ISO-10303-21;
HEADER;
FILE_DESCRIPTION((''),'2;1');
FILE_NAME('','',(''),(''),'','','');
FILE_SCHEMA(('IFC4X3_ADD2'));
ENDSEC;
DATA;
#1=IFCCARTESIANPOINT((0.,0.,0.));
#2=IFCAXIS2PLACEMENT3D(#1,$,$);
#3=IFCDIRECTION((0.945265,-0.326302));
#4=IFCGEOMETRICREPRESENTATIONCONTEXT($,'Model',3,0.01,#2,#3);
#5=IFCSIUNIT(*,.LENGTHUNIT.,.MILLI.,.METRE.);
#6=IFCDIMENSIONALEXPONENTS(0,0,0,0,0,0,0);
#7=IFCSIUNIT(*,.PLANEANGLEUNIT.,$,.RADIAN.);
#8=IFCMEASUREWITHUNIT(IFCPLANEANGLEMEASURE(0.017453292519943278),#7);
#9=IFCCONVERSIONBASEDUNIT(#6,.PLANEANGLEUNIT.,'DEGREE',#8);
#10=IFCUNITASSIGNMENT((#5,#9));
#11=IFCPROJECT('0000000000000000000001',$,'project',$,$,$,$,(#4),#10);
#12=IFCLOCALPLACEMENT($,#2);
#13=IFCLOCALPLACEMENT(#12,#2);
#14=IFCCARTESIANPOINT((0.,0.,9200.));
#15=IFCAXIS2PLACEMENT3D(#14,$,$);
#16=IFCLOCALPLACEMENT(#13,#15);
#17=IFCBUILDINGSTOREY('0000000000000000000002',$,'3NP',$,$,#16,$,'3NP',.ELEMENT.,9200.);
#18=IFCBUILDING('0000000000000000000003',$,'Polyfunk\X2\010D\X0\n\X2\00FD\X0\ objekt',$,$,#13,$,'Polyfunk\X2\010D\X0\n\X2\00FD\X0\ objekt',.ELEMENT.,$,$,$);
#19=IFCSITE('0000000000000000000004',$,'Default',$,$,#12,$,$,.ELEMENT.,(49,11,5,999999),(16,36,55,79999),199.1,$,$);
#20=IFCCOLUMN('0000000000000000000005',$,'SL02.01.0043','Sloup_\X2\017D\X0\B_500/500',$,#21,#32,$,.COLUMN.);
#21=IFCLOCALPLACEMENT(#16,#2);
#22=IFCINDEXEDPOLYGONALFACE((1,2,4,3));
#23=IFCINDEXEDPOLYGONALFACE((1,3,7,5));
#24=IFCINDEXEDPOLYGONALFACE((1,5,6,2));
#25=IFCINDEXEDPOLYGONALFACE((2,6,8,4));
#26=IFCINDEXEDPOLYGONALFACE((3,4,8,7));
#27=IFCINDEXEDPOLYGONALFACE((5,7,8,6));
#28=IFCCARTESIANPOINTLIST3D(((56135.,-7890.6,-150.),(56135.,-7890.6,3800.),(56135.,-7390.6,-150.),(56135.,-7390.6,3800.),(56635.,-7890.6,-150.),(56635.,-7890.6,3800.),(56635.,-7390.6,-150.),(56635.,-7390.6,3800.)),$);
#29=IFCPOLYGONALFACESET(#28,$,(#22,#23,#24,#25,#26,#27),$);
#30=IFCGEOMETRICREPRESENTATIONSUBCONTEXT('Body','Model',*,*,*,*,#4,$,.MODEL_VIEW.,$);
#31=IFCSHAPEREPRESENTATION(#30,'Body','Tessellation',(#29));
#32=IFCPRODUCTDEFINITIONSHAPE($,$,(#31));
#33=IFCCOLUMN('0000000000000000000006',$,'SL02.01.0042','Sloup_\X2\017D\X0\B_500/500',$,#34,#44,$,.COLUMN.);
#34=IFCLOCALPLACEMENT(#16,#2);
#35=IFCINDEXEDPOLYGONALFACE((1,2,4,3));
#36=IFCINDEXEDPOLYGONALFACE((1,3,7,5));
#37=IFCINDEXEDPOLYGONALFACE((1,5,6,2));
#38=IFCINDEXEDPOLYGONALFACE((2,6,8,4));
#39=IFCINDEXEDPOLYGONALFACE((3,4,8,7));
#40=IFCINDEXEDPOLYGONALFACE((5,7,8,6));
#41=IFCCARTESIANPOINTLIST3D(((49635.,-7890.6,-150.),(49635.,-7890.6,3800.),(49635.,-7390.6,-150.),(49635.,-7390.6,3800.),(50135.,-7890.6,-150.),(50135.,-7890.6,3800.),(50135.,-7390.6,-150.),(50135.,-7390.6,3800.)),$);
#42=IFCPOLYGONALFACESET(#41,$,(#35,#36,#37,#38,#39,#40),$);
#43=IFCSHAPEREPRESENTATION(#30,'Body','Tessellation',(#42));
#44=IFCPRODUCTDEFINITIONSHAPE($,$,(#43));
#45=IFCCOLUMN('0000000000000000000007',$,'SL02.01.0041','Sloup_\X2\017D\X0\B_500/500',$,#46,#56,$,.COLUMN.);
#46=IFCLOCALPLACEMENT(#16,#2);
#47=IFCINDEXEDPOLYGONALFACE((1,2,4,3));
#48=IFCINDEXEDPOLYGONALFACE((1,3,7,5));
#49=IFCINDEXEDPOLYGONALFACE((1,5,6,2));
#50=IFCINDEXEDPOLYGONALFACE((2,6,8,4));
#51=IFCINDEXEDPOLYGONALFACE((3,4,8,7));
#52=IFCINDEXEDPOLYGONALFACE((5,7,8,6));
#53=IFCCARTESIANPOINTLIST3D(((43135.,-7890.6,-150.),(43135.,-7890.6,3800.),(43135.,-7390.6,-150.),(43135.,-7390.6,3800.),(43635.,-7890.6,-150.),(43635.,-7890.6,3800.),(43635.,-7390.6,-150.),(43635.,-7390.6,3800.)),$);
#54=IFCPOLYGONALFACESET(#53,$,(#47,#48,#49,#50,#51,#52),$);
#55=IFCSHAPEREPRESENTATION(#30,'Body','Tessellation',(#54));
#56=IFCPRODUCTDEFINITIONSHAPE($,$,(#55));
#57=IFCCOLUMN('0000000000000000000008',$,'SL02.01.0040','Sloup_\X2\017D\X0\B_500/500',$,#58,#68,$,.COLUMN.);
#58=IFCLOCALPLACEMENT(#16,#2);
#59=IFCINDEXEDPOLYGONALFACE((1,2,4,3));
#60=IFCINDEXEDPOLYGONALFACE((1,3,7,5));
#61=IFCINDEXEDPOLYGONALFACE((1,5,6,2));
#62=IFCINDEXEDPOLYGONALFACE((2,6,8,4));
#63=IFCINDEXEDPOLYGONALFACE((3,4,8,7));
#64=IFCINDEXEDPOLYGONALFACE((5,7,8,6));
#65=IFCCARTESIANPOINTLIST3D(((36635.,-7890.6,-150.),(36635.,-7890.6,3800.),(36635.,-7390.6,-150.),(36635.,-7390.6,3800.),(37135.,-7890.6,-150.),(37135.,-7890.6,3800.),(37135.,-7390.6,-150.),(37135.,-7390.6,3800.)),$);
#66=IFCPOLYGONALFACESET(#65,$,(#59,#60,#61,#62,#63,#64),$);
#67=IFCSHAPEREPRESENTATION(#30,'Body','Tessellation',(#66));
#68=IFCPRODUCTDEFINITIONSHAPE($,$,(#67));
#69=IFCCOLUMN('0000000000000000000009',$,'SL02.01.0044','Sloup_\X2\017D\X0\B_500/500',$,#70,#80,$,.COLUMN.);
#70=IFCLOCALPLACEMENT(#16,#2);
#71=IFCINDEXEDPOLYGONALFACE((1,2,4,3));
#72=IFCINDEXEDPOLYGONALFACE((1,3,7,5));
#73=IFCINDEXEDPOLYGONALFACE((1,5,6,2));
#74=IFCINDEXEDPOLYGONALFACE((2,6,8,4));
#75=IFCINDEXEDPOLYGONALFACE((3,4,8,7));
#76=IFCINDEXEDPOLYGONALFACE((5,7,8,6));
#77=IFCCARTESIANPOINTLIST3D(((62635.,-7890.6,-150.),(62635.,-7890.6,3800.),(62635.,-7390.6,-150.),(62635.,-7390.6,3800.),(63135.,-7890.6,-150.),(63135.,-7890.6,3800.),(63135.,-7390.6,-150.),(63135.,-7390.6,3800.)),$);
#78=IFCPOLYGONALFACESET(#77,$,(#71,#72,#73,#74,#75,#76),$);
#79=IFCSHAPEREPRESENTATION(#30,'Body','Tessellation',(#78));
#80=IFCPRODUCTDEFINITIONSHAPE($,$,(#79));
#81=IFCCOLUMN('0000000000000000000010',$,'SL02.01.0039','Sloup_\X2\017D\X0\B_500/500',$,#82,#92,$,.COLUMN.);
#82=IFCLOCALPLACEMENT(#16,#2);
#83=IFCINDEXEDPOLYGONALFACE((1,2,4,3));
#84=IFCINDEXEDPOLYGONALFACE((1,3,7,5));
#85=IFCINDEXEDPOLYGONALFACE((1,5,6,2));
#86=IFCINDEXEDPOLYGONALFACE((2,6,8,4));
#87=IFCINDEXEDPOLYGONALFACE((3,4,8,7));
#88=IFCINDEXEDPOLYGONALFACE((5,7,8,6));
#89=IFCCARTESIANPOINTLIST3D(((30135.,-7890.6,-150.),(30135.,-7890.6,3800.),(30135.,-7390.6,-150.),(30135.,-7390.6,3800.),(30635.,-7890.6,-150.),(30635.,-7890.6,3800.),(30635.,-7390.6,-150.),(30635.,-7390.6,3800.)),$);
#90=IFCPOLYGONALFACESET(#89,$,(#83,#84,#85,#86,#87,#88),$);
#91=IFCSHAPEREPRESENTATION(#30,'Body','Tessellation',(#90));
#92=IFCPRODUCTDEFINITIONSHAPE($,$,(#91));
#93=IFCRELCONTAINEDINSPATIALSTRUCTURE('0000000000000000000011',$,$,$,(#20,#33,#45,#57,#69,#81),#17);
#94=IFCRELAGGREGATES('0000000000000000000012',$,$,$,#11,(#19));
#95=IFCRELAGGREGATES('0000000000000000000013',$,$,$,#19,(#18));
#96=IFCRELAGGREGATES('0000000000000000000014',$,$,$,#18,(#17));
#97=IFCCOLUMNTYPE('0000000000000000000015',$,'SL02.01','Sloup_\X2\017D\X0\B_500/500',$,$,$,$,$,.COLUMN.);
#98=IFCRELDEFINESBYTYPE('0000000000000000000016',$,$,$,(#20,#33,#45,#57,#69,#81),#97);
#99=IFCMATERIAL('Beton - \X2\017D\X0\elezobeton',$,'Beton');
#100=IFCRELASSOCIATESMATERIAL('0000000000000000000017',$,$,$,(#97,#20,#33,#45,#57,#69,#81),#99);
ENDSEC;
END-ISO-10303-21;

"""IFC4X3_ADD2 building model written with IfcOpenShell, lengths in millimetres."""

from ifc_helpers import new_model, entity, si_unit, converted_unit, direction, frame, frame_2d, origin, origin_2d_with_axis, place, context, subcontext, project, spatial, rectangle, extrude, source, transform, mapped, material, material_profile, profile_set, profile_usage, type_object, element, save


model = new_model("IFC4X3_ADD2")

# Units and contexts
model_context = context("Model", 3, precision=0.01, world=origin(), true_north=direction((0.945265, -0.326302)))
body_context = subcontext(model_context, "Body", "Model", "MODEL_VIEW")
ifc_project = project(units=[si_unit("LENGTHUNIT", "METRE", prefix="MILLI"), converted_unit("PLANEANGLEUNIT", "DEGREE", entity("IfcPlaneAngleMeasure", 0.017453292519943278), si_unit("PLANEANGLEUNIT", "RADIAN"), dimensions=[0, 0, 0, 0, 0, 0, 0])], contexts=[model_context])

# Site, building, storey
site_placement = place(None, origin())
site = spatial("IfcSite", under=ifc_project, at=site_placement, Name="Default", CompositionType="ELEMENT", RefLatitude=(49, 11, 5, 999999), RefLongitude=(16, 36, 55, 79999), RefElevation=199.1)
building_placement = place(site_placement, origin())
building = spatial("IfcBuilding", under=site, at=building_placement, Name="Polyfunkčný objekt", LongName="Polyfunkčný objekt", CompositionType="ELEMENT")
storey_placement = place(building_placement, frame((0.0, 0.0, 9200.0)))
storey = spatial("IfcBuildingStorey", under=building, at=storey_placement, Name="3NP", LongName="3NP", CompositionType="ELEMENT", Elevation=9200.0)

# Columns
ifc_material_1 = material(Name="Beton - Železobeton", Category="Beton")
ifc_material_profile_1 = material_profile(ifc_material_1, rectangle(XDim=500.0, YDim=500.0, at=frame_2d((0.0, 0.0), x_axis=(1.0, 0.0))), Name="Sloup_ŽB_500/500")
ifc_profile_set_1 = profile_set([ifc_material_profile_1], Name="Sloup_ŽB_500/500")
ifc_profile_usage_1 = profile_usage(ifc_profile_set_1)
column_type_1 = type_object("IfcColumnType", Name="SL02.01", Description="Sloup_ŽB_500/500", PredefinedType="COLUMN", material=ifc_profile_set_1)
shared_shape_1 = source(origin(), body_context, "Body", "SweptSolid", [
    extrude(rectangle(XDim=500.0, YDim=500.0, at=origin_2d_with_axis()), frame((56385.0, -7640.6, 9050.0)), (0.0, 0.0, 1.0), 3950.0),
])
column_1_placement = place(storey_placement, frame((0.0, 0.0, -9200.0)))
element("IfcColumn", 1, at=column_1_placement, inside=storey, type_object=column_type_1, material=ifc_profile_usage_1, Name="SL02.01.0043", Description="Sloup_ŽB_500/500", PredefinedType="COLUMN", context=body_context, shape_type="MappedRepresentation", body=[
    mapped(shared_shape_1, transform((0.0, 0.0, 0.0), scale=1.0)),
])
shared_shape_2 = source(origin(), body_context, "Body", "SweptSolid", [
    extrude(rectangle(XDim=500.0, YDim=500.0, at=frame_2d((0.0, 0.0), x_axis=(1.0, 0.0))), frame((49885.0, -7640.6, 9050.0)), (0.0, 0.0, 1.0), 3950.0),
])
column_2_placement = place(storey_placement, frame((0.0, 0.0, -9200.0)))
element("IfcColumn", 2, at=column_2_placement, inside=storey, type_object=column_type_1, material=ifc_profile_usage_1, Name="SL02.01.0042", Description="Sloup_ŽB_500/500", PredefinedType="COLUMN", context=body_context, shape_type="MappedRepresentation", body=[
    mapped(shared_shape_2, transform((0.0, 0.0, 0.0), scale=1.0)),
])
shared_shape_3 = source(origin(), body_context, "Body", "SweptSolid", [
    extrude(rectangle(XDim=500.0, YDim=500.0, at=origin_2d_with_axis()), frame((43385.0, -7640.6, 9050.0)), (0.0, 0.0, 1.0), 3950.0),
])
column_3_placement = place(storey_placement, frame((0.0, 0.0, -9200.0)))
element("IfcColumn", 3, at=column_3_placement, inside=storey, type_object=column_type_1, material=ifc_profile_usage_1, Name="SL02.01.0041", Description="Sloup_ŽB_500/500", PredefinedType="COLUMN", context=body_context, shape_type="MappedRepresentation", body=[
    mapped(shared_shape_3, transform((0.0, 0.0, 0.0), scale=1.0)),
])
shared_shape_4 = source(origin(), body_context, "Body", "SweptSolid", [
    extrude(rectangle(XDim=500.0, YDim=500.0, at=origin_2d_with_axis()), frame((36885.0, -7640.6, 9050.0)), (0.0, 0.0, 1.0), 3950.0),
])
column_4_placement = place(storey_placement, frame((0.0, 0.0, -9200.0)))
element("IfcColumn", 4, at=column_4_placement, inside=storey, type_object=column_type_1, material=ifc_profile_usage_1, Name="SL02.01.0040", Description="Sloup_ŽB_500/500", PredefinedType="COLUMN", context=body_context, shape_type="MappedRepresentation", body=[
    mapped(shared_shape_4, transform((0.0, 0.0, 0.0), scale=1.0)),
])
shared_shape_5 = source(origin(), body_context, "Body", "SweptSolid", [
    extrude(rectangle(XDim=500.0, YDim=500.0, at=frame_2d((0.0, 0.0), x_axis=(1.0, 0.0))), frame((62885.0, -7640.6, 9050.0), z_axis=(0.0, 0.0, 1.0), x_axis=(-1.0, 0.0, 0.0)), (0.0, 0.0, 1.0), 3950.0),
])
column_5_placement = place(storey_placement, frame((0.0, 0.0, -9200.0)))
element("IfcColumn", 5, at=column_5_placement, inside=storey, type_object=column_type_1, material=ifc_profile_usage_1, Name="SL02.01.0044", Description="Sloup_ŽB_500/500", PredefinedType="COLUMN", context=body_context, shape_type="MappedRepresentation", body=[
    mapped(shared_shape_5, transform((0.0, 0.0, 0.0), scale=1.0)),
])
shared_shape_6 = source(origin(), body_context, "Body", "SweptSolid", [
    extrude(rectangle(XDim=500.0, YDim=500.0, at=frame_2d((0.0, 0.0), x_axis=(1.0, 0.0))), frame((30385.0, -7640.6, 9050.0), z_axis=(0.0, 0.0, 1.0), x_axis=(-1.0, 0.0, 0.0)), (0.0, 0.0, 1.0), 3950.0),
])
column_6_placement = place(storey_placement, frame((0.0, 0.0, -9200.0)))
element("IfcColumn", 6, at=column_6_placement, inside=storey, type_object=column_type_1, material=ifc_profile_usage_1, Name="SL02.01.0039", Description="Sloup_ŽB_500/500", PredefinedType="COLUMN", context=body_context, shape_type="MappedRepresentation", body=[
    mapped(shared_shape_6, transform((0.0, 0.0, 0.0), scale=1.0)),
])

save(model, "model.ifc")
